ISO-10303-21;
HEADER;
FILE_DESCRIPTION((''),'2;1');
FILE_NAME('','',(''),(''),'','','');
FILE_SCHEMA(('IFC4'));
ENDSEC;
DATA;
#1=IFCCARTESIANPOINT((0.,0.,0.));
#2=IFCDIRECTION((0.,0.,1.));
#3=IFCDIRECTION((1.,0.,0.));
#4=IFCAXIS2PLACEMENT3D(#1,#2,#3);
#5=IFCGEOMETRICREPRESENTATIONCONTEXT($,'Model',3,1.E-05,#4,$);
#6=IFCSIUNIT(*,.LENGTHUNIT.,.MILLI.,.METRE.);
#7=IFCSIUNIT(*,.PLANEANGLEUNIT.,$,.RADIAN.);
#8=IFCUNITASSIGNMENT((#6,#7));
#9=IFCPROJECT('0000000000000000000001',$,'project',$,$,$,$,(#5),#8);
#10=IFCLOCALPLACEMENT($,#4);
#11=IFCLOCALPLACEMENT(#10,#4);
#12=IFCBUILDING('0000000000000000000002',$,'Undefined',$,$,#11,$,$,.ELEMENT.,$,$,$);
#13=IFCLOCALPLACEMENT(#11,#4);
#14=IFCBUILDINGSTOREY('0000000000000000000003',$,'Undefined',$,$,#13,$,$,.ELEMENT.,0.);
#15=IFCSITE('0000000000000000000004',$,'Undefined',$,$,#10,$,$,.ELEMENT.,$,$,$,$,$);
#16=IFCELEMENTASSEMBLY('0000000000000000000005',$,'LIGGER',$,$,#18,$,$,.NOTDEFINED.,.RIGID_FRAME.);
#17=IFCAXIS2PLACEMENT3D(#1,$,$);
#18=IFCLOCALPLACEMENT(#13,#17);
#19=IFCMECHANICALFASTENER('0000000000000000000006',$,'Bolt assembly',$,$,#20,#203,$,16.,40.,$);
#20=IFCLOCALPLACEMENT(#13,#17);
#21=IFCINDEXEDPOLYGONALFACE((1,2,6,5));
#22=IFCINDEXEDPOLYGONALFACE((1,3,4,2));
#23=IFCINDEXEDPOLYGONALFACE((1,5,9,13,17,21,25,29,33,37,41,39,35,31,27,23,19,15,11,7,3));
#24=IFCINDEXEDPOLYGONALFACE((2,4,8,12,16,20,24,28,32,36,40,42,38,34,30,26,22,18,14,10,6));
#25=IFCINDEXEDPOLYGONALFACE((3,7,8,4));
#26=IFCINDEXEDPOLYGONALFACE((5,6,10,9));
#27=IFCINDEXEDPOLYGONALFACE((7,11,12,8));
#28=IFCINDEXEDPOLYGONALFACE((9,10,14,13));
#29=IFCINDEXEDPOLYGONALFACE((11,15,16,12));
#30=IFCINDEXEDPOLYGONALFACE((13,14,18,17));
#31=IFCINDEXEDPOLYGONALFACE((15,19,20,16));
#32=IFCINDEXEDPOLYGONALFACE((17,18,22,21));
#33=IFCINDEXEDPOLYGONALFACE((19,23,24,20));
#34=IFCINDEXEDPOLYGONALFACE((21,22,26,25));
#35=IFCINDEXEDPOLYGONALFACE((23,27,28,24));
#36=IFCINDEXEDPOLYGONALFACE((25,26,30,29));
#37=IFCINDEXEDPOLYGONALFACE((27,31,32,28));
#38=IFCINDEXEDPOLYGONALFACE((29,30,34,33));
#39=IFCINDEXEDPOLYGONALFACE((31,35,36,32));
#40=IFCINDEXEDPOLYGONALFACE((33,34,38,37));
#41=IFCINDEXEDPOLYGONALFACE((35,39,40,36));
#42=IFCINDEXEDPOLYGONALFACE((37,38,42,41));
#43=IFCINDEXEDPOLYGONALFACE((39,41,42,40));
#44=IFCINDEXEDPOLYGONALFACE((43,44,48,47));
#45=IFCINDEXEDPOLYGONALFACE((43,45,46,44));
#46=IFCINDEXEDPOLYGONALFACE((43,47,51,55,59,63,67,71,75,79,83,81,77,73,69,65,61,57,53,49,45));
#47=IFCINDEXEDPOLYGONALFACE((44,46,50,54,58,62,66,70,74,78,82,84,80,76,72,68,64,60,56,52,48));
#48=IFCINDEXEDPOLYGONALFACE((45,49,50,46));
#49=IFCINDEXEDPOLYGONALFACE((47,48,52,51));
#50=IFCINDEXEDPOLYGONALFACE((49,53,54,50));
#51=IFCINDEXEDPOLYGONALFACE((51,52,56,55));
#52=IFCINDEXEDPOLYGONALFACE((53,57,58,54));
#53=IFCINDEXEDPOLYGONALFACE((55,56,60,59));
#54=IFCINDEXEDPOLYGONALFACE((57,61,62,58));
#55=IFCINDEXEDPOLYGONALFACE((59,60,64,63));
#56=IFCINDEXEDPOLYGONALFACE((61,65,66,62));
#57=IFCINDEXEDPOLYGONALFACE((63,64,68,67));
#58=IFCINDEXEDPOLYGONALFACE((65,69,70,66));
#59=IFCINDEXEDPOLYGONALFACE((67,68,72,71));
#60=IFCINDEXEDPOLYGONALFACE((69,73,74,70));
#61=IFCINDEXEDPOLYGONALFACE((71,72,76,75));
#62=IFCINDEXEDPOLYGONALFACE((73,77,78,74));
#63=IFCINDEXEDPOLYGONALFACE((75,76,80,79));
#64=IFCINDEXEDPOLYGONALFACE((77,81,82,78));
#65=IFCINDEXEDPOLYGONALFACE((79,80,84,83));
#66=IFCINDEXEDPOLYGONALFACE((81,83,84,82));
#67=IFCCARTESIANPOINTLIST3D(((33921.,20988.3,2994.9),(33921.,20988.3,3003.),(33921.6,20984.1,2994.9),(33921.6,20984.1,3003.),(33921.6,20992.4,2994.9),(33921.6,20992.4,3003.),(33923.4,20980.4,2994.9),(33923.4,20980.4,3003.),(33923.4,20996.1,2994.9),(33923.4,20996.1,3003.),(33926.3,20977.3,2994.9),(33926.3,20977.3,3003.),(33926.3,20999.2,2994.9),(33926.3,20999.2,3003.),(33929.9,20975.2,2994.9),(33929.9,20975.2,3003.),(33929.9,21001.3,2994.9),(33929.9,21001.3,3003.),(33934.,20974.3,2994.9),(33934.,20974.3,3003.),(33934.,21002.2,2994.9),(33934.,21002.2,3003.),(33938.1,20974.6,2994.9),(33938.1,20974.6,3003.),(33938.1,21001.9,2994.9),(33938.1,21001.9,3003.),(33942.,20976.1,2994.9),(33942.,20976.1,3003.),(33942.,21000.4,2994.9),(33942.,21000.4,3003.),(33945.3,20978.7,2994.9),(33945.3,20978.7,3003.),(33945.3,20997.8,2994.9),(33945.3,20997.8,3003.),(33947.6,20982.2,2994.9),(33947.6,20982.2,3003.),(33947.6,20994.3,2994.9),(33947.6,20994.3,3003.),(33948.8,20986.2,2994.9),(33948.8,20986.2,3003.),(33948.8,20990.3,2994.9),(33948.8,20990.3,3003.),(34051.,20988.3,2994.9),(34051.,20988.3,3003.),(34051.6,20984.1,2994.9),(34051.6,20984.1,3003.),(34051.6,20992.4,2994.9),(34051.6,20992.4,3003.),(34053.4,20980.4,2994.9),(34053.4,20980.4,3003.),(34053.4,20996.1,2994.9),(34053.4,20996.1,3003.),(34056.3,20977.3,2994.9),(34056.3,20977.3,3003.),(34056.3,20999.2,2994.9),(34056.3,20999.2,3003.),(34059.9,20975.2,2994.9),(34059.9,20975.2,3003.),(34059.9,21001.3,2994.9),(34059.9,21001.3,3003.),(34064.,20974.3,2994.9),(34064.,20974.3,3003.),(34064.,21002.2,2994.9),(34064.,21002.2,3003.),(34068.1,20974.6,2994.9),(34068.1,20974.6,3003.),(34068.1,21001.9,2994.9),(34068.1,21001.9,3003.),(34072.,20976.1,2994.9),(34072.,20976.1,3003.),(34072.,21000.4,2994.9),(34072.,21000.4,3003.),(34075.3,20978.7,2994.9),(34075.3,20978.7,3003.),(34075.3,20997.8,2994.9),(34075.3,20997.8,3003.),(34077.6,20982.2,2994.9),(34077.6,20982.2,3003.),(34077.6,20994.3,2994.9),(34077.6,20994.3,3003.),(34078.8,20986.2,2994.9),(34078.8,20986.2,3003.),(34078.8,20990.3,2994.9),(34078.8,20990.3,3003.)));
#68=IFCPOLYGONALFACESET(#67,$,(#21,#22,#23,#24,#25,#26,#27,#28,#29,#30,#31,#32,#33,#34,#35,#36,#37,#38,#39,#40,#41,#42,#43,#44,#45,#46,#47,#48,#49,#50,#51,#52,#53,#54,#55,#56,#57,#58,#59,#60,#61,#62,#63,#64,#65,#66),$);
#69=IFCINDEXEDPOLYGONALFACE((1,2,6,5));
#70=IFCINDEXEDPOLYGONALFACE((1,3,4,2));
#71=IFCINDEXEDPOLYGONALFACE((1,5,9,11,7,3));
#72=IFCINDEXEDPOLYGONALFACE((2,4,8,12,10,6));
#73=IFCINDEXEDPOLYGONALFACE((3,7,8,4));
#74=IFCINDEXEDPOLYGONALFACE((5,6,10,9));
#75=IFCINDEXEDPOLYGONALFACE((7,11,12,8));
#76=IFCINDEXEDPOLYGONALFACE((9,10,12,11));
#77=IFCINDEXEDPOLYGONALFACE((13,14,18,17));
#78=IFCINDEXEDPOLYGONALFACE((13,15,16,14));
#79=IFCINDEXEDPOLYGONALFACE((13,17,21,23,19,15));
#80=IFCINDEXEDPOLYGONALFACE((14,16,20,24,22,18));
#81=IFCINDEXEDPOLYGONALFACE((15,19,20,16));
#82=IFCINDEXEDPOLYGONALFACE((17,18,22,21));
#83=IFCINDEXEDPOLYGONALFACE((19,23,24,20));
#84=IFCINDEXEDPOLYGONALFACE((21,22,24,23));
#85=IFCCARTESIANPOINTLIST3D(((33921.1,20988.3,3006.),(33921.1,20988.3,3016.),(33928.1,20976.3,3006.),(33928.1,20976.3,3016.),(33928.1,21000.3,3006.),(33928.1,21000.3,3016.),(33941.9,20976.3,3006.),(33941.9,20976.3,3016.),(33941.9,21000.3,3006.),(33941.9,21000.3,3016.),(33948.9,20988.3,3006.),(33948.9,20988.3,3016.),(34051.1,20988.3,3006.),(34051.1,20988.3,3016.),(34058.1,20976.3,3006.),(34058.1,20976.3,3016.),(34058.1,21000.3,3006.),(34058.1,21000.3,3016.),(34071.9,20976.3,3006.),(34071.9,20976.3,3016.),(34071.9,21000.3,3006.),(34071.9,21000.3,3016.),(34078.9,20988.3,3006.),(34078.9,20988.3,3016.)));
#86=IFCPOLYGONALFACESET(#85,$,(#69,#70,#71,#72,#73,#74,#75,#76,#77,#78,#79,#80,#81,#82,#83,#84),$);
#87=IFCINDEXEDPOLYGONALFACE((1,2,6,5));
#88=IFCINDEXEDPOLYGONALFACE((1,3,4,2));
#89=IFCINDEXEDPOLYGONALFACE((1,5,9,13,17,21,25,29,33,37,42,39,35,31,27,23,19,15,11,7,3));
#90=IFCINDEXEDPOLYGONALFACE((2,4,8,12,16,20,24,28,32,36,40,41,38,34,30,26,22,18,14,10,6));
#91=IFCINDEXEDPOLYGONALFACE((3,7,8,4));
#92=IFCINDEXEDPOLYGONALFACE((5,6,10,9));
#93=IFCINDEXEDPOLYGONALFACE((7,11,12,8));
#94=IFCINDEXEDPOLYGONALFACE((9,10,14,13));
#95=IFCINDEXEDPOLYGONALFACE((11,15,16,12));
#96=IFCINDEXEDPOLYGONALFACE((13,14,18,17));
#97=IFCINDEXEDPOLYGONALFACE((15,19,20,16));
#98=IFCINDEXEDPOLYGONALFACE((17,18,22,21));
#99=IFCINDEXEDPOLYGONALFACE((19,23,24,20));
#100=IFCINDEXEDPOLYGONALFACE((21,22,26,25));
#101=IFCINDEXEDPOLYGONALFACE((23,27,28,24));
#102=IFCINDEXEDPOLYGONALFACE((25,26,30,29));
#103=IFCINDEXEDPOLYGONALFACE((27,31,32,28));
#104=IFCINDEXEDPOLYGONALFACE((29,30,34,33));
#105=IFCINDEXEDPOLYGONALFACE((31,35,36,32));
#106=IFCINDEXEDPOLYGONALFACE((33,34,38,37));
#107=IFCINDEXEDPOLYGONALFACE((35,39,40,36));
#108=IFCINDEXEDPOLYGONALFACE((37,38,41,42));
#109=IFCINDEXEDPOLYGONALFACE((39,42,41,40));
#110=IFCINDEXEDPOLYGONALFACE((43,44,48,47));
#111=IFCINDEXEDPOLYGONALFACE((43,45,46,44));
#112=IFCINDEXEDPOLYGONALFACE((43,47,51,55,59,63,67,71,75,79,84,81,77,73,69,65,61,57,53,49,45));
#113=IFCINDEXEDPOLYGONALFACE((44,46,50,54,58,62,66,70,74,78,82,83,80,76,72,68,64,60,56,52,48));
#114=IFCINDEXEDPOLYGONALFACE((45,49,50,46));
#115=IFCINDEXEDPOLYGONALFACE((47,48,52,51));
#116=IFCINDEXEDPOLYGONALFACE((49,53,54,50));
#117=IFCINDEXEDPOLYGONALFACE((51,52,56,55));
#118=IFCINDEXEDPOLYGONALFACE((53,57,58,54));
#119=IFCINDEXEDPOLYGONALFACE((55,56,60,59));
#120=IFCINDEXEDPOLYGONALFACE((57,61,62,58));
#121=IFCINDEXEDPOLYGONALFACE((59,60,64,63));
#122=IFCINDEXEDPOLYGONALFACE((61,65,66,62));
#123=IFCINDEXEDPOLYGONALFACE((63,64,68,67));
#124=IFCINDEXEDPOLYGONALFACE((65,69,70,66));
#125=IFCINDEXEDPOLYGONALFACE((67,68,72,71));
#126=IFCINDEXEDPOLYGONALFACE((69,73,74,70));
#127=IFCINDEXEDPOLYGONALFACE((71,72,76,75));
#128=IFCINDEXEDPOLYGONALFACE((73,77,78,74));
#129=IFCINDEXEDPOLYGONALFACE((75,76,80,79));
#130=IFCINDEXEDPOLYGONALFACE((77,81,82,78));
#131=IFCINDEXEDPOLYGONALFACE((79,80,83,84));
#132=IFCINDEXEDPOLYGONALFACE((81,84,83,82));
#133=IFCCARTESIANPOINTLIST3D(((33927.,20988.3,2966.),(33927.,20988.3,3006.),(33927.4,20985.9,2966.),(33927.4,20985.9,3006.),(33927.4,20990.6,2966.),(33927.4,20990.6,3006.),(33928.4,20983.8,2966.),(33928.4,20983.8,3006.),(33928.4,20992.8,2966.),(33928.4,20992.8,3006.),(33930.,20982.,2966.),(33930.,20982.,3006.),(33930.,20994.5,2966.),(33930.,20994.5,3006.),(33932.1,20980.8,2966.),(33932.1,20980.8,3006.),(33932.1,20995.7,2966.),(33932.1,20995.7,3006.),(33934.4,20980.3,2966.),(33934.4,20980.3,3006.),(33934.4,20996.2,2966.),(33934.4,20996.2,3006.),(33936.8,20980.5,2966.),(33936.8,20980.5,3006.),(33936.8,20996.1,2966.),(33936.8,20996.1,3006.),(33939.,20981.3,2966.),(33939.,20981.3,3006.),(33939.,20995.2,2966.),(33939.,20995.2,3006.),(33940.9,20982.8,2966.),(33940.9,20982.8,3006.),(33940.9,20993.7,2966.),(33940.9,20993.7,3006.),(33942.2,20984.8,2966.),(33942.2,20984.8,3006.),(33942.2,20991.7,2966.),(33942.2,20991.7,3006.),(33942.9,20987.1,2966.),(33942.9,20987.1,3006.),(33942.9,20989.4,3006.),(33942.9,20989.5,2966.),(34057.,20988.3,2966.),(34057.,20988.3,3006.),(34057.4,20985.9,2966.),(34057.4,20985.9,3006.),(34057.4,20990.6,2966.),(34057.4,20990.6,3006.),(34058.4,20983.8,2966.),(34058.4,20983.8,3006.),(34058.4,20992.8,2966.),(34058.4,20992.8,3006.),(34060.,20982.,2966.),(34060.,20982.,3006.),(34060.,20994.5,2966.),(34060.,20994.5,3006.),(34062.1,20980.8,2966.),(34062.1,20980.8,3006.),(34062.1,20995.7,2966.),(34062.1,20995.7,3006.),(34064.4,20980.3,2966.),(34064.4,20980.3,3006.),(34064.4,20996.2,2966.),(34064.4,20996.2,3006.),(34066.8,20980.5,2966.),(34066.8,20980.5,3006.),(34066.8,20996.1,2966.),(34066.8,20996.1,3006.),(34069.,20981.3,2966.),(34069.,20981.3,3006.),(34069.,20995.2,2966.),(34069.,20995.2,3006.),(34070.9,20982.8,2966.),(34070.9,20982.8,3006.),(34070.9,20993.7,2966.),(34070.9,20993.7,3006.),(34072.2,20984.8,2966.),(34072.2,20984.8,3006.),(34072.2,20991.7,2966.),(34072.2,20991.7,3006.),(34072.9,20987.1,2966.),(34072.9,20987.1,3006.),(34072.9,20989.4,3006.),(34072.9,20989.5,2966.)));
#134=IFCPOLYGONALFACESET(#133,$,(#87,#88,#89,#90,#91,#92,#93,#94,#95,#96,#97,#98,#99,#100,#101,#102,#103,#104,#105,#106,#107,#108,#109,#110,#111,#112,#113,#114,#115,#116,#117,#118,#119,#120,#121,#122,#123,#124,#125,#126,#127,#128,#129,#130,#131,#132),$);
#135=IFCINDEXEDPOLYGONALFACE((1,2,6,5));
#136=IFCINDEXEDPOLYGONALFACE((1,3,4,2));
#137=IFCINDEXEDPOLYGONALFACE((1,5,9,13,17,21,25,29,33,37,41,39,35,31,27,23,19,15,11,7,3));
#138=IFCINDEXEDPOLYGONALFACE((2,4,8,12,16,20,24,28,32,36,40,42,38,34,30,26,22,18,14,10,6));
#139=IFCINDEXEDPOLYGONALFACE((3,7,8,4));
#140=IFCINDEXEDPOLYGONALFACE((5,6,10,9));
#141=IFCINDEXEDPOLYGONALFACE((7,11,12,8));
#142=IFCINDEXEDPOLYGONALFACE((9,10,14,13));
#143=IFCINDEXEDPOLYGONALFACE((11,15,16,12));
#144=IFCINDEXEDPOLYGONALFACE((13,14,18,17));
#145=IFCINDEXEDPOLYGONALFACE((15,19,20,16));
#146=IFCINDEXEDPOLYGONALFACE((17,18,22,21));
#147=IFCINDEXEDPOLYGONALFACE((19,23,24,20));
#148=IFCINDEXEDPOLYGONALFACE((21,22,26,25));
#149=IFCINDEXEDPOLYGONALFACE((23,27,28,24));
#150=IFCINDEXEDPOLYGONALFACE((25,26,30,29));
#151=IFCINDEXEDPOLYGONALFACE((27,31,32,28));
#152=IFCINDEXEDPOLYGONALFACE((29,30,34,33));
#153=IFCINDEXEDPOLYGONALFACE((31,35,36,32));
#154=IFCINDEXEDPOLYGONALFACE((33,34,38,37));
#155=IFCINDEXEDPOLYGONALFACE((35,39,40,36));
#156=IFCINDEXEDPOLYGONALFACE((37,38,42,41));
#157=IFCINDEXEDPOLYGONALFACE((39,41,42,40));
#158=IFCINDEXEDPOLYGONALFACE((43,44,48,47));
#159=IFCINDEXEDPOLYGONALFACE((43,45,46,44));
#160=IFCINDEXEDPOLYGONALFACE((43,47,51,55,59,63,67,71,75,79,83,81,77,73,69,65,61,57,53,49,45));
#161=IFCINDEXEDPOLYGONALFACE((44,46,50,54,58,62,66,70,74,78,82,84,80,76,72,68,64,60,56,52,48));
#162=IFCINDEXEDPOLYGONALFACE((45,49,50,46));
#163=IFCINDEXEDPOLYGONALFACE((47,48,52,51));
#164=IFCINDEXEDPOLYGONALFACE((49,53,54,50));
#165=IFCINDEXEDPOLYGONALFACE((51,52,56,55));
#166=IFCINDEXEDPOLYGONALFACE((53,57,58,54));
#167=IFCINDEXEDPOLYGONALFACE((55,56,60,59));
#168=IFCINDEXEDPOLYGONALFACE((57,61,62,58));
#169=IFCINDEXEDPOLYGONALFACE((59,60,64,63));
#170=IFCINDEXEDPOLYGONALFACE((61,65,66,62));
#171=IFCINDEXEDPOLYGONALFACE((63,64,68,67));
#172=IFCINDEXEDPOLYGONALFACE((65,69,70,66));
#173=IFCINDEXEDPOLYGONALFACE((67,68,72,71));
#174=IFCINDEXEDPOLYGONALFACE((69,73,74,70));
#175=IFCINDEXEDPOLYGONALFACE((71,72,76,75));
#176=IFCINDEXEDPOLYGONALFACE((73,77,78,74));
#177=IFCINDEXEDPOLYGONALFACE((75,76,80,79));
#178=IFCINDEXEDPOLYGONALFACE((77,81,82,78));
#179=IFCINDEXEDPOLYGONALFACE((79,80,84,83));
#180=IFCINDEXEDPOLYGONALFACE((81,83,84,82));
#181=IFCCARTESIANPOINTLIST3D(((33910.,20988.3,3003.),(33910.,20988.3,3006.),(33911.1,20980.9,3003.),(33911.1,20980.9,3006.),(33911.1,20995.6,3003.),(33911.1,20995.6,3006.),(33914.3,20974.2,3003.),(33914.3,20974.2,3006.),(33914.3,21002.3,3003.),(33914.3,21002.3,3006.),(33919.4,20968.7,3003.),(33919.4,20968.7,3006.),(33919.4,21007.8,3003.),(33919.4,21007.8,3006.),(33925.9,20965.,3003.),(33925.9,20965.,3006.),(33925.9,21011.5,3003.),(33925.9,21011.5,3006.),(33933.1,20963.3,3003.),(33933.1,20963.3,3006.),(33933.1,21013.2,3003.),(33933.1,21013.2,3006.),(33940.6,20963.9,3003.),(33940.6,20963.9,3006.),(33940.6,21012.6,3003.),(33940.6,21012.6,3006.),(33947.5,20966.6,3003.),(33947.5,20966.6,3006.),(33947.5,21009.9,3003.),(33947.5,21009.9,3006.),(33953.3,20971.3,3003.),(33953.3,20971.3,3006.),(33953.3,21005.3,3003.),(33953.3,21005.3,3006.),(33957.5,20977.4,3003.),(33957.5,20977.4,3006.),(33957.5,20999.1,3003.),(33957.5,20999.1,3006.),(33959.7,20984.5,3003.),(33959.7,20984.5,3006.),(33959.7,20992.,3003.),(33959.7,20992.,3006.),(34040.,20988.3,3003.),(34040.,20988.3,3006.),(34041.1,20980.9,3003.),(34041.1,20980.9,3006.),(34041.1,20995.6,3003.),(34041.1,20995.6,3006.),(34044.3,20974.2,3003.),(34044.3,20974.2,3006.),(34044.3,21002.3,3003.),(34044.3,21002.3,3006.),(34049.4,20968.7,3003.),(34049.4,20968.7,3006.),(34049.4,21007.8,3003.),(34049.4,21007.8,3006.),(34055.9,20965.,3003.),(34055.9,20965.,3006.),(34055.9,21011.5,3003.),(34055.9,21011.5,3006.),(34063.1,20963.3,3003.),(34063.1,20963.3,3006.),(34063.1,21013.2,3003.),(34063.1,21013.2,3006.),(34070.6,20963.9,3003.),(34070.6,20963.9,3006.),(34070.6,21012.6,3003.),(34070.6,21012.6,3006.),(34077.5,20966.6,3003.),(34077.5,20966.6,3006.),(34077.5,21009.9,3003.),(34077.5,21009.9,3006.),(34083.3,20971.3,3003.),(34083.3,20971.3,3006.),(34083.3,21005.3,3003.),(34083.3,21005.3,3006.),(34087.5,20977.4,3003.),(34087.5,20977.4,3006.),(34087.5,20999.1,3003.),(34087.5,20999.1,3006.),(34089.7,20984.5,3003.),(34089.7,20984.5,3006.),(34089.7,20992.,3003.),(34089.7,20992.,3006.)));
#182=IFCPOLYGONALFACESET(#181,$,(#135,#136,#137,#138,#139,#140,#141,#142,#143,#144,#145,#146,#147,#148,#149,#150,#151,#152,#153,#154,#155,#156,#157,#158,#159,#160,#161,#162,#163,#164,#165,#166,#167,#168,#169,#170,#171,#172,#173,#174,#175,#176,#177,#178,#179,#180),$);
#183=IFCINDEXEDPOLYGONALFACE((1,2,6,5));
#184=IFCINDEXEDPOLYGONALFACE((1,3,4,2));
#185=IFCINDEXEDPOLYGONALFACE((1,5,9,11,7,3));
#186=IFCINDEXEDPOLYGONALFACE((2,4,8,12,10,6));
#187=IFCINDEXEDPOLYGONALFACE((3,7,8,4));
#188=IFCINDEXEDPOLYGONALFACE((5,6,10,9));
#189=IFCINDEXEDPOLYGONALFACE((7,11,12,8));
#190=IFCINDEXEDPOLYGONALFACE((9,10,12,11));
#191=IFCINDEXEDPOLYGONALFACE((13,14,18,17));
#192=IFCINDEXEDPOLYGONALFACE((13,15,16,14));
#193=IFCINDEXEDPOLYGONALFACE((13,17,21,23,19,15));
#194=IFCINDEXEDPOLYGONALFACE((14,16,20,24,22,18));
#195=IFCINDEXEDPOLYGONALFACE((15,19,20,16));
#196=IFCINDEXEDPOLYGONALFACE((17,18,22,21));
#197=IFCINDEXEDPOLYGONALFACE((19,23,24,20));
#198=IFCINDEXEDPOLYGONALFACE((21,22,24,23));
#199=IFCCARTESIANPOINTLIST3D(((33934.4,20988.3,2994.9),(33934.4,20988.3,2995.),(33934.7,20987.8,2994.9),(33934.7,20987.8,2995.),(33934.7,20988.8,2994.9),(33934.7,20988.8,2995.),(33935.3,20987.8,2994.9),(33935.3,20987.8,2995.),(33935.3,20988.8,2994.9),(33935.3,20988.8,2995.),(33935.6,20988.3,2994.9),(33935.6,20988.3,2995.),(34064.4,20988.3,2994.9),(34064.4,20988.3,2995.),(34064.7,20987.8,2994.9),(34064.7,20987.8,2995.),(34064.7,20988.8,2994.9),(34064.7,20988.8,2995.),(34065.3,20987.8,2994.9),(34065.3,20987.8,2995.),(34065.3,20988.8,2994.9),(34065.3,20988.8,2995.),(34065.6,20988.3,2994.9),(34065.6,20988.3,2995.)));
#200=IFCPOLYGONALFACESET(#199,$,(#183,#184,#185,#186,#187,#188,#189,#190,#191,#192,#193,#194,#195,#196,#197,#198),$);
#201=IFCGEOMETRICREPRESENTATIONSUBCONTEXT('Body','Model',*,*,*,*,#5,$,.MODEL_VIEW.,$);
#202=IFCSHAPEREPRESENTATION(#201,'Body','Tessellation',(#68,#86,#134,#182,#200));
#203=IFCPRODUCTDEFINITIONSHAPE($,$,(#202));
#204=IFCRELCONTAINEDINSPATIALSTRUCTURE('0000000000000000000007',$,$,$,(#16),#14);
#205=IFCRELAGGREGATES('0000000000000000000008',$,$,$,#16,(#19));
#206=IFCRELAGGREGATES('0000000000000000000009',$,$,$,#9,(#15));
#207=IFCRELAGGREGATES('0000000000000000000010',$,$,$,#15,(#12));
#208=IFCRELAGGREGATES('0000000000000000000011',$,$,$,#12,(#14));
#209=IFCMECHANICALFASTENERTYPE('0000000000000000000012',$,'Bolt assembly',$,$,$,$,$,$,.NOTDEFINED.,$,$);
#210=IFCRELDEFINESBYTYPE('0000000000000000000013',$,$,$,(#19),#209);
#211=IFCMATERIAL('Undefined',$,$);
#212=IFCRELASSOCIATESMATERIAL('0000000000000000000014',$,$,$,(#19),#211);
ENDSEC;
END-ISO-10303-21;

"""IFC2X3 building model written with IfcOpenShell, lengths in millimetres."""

from ifc_helpers import new_model, si_unit, frame, origin_with_axes, origin_2d_with_axis, place, context, subcontext, project, spatial, polyline, circle, outline, extrude, source, transform, mapped, material, type_object, element, aggregate, save


model = new_model("IFC2X3")

# Units and contexts
model_context = context("Model", 3, precision=1e-05, world=origin_with_axes())
body_context = subcontext(model_context, "Body", "Model", "MODEL_VIEW")
ifc_project = project(units=[si_unit("LENGTHUNIT", "METRE", prefix="MILLI"), si_unit("PLANEANGLEUNIT", "RADIAN")], contexts=[model_context])

# Site, building, storey
site_placement = place(None, origin_with_axes())
site = spatial("IfcSite", under=ifc_project, at=site_placement, Name="Undefined", CompositionType="ELEMENT")
building_placement = place(site_placement, origin_with_axes())
building = spatial("IfcBuilding", under=site, at=building_placement, Name="Undefined", CompositionType="ELEMENT")
storey_placement = place(building_placement, origin_with_axes())
storey = spatial("IfcBuildingStorey", under=building, at=storey_placement, Name="Undefined", CompositionType="ELEMENT", Elevation=0.0)

# Element assembly, mechanical fastener
assembly_1_placement = place(storey_placement, origin_with_axes())
assembly_1 = element("IfcElementAssembly", 1, at=assembly_1_placement, inside=storey, Name="LIGGER", AssemblyPlace="NOTDEFINED", PredefinedType="RIGID_FRAME")
ifc_material_1 = material(Name="Undefined")
mechanical_fastener_type = type_object("IfcMechanicalFastenerType", Name="Bolt assembly")
shared_shape_1 = source(origin_with_axes(), body_context, "Body", "SweptSolid", [
    extrude(circle(Radius=14.0, at=origin_2d_with_axis()), frame((0.0, 0.0, 0.0), z_axis=(0.0, 1.0, 0.0), x_axis=(1.0, 0.0, 0.0)), (0.0, 0.0, 1.0), 8.1),
    extrude(outline(polyline([(13.9, 0.0), (6.9, 12.0), (-6.9, 12.0), (-13.9, 0.0), (-6.9, -12.0), (6.9, -12.0), (13.9, 0.0)])), frame((0.0, -13.0, 0.0), z_axis=(0.0, 1.0, 0.0), x_axis=(1.0, 0.0, 0.0)), (0.0, 0.0, 1.0), 10.0),
    extrude(circle(Radius=8.0, at=origin_2d_with_axis()), frame((0.0, -3.0, 0.0), z_axis=(0.0, 1.0, 0.0), x_axis=(1.0, 0.0, 0.0)), (0.0, 0.0, 1.0), 40.0),
    extrude(circle(Radius=25.0, at=origin_2d_with_axis()), frame((0.0, -3.0, 0.0), z_axis=(0.0, 1.0, 0.0), x_axis=(1.0, 0.0, 0.0)), (0.0, 0.0, 1.0), 3.0),
    extrude(outline(polyline([(0.6, 0.0), (0.3, 0.5), (-0.3, 0.5), (-0.6, 0.0), (-0.3, -0.5), (0.3, -0.5), (0.6, 0.0)])), frame((0.0, 8.0, 0.0), z_axis=(0.0, 1.0, 0.0), x_axis=(1.0, 0.0, 0.0)), (0.0, 0.0, 1.0), 0.1),
])
mechanical_fastener_1_placement = place(assembly_1_placement, frame((34065.0, 20988.3, 3003.0), z_axis=(0.0, -1.0, -0.000196), x_axis=(-1.0, 0.0, 0.0)))
mechanical_fastener_1 = element("IfcMechanicalFastener", 2, at=mechanical_fastener_1_placement, type_object=mechanical_fastener_type, material=ifc_material_1, Name="Bolt assembly", NominalDiameter=16.0, NominalLength=40.0, context=body_context, shape_type="MappedRepresentation", body=[
    mapped(shared_shape_1, transform((0.0, 0.0, 0.0))),
    mapped(shared_shape_1, transform((130.0, 0.0, 0.0))),
])
aggregate(assembly_1, [mechanical_fastener_1])

save(model, "model.ifc")
